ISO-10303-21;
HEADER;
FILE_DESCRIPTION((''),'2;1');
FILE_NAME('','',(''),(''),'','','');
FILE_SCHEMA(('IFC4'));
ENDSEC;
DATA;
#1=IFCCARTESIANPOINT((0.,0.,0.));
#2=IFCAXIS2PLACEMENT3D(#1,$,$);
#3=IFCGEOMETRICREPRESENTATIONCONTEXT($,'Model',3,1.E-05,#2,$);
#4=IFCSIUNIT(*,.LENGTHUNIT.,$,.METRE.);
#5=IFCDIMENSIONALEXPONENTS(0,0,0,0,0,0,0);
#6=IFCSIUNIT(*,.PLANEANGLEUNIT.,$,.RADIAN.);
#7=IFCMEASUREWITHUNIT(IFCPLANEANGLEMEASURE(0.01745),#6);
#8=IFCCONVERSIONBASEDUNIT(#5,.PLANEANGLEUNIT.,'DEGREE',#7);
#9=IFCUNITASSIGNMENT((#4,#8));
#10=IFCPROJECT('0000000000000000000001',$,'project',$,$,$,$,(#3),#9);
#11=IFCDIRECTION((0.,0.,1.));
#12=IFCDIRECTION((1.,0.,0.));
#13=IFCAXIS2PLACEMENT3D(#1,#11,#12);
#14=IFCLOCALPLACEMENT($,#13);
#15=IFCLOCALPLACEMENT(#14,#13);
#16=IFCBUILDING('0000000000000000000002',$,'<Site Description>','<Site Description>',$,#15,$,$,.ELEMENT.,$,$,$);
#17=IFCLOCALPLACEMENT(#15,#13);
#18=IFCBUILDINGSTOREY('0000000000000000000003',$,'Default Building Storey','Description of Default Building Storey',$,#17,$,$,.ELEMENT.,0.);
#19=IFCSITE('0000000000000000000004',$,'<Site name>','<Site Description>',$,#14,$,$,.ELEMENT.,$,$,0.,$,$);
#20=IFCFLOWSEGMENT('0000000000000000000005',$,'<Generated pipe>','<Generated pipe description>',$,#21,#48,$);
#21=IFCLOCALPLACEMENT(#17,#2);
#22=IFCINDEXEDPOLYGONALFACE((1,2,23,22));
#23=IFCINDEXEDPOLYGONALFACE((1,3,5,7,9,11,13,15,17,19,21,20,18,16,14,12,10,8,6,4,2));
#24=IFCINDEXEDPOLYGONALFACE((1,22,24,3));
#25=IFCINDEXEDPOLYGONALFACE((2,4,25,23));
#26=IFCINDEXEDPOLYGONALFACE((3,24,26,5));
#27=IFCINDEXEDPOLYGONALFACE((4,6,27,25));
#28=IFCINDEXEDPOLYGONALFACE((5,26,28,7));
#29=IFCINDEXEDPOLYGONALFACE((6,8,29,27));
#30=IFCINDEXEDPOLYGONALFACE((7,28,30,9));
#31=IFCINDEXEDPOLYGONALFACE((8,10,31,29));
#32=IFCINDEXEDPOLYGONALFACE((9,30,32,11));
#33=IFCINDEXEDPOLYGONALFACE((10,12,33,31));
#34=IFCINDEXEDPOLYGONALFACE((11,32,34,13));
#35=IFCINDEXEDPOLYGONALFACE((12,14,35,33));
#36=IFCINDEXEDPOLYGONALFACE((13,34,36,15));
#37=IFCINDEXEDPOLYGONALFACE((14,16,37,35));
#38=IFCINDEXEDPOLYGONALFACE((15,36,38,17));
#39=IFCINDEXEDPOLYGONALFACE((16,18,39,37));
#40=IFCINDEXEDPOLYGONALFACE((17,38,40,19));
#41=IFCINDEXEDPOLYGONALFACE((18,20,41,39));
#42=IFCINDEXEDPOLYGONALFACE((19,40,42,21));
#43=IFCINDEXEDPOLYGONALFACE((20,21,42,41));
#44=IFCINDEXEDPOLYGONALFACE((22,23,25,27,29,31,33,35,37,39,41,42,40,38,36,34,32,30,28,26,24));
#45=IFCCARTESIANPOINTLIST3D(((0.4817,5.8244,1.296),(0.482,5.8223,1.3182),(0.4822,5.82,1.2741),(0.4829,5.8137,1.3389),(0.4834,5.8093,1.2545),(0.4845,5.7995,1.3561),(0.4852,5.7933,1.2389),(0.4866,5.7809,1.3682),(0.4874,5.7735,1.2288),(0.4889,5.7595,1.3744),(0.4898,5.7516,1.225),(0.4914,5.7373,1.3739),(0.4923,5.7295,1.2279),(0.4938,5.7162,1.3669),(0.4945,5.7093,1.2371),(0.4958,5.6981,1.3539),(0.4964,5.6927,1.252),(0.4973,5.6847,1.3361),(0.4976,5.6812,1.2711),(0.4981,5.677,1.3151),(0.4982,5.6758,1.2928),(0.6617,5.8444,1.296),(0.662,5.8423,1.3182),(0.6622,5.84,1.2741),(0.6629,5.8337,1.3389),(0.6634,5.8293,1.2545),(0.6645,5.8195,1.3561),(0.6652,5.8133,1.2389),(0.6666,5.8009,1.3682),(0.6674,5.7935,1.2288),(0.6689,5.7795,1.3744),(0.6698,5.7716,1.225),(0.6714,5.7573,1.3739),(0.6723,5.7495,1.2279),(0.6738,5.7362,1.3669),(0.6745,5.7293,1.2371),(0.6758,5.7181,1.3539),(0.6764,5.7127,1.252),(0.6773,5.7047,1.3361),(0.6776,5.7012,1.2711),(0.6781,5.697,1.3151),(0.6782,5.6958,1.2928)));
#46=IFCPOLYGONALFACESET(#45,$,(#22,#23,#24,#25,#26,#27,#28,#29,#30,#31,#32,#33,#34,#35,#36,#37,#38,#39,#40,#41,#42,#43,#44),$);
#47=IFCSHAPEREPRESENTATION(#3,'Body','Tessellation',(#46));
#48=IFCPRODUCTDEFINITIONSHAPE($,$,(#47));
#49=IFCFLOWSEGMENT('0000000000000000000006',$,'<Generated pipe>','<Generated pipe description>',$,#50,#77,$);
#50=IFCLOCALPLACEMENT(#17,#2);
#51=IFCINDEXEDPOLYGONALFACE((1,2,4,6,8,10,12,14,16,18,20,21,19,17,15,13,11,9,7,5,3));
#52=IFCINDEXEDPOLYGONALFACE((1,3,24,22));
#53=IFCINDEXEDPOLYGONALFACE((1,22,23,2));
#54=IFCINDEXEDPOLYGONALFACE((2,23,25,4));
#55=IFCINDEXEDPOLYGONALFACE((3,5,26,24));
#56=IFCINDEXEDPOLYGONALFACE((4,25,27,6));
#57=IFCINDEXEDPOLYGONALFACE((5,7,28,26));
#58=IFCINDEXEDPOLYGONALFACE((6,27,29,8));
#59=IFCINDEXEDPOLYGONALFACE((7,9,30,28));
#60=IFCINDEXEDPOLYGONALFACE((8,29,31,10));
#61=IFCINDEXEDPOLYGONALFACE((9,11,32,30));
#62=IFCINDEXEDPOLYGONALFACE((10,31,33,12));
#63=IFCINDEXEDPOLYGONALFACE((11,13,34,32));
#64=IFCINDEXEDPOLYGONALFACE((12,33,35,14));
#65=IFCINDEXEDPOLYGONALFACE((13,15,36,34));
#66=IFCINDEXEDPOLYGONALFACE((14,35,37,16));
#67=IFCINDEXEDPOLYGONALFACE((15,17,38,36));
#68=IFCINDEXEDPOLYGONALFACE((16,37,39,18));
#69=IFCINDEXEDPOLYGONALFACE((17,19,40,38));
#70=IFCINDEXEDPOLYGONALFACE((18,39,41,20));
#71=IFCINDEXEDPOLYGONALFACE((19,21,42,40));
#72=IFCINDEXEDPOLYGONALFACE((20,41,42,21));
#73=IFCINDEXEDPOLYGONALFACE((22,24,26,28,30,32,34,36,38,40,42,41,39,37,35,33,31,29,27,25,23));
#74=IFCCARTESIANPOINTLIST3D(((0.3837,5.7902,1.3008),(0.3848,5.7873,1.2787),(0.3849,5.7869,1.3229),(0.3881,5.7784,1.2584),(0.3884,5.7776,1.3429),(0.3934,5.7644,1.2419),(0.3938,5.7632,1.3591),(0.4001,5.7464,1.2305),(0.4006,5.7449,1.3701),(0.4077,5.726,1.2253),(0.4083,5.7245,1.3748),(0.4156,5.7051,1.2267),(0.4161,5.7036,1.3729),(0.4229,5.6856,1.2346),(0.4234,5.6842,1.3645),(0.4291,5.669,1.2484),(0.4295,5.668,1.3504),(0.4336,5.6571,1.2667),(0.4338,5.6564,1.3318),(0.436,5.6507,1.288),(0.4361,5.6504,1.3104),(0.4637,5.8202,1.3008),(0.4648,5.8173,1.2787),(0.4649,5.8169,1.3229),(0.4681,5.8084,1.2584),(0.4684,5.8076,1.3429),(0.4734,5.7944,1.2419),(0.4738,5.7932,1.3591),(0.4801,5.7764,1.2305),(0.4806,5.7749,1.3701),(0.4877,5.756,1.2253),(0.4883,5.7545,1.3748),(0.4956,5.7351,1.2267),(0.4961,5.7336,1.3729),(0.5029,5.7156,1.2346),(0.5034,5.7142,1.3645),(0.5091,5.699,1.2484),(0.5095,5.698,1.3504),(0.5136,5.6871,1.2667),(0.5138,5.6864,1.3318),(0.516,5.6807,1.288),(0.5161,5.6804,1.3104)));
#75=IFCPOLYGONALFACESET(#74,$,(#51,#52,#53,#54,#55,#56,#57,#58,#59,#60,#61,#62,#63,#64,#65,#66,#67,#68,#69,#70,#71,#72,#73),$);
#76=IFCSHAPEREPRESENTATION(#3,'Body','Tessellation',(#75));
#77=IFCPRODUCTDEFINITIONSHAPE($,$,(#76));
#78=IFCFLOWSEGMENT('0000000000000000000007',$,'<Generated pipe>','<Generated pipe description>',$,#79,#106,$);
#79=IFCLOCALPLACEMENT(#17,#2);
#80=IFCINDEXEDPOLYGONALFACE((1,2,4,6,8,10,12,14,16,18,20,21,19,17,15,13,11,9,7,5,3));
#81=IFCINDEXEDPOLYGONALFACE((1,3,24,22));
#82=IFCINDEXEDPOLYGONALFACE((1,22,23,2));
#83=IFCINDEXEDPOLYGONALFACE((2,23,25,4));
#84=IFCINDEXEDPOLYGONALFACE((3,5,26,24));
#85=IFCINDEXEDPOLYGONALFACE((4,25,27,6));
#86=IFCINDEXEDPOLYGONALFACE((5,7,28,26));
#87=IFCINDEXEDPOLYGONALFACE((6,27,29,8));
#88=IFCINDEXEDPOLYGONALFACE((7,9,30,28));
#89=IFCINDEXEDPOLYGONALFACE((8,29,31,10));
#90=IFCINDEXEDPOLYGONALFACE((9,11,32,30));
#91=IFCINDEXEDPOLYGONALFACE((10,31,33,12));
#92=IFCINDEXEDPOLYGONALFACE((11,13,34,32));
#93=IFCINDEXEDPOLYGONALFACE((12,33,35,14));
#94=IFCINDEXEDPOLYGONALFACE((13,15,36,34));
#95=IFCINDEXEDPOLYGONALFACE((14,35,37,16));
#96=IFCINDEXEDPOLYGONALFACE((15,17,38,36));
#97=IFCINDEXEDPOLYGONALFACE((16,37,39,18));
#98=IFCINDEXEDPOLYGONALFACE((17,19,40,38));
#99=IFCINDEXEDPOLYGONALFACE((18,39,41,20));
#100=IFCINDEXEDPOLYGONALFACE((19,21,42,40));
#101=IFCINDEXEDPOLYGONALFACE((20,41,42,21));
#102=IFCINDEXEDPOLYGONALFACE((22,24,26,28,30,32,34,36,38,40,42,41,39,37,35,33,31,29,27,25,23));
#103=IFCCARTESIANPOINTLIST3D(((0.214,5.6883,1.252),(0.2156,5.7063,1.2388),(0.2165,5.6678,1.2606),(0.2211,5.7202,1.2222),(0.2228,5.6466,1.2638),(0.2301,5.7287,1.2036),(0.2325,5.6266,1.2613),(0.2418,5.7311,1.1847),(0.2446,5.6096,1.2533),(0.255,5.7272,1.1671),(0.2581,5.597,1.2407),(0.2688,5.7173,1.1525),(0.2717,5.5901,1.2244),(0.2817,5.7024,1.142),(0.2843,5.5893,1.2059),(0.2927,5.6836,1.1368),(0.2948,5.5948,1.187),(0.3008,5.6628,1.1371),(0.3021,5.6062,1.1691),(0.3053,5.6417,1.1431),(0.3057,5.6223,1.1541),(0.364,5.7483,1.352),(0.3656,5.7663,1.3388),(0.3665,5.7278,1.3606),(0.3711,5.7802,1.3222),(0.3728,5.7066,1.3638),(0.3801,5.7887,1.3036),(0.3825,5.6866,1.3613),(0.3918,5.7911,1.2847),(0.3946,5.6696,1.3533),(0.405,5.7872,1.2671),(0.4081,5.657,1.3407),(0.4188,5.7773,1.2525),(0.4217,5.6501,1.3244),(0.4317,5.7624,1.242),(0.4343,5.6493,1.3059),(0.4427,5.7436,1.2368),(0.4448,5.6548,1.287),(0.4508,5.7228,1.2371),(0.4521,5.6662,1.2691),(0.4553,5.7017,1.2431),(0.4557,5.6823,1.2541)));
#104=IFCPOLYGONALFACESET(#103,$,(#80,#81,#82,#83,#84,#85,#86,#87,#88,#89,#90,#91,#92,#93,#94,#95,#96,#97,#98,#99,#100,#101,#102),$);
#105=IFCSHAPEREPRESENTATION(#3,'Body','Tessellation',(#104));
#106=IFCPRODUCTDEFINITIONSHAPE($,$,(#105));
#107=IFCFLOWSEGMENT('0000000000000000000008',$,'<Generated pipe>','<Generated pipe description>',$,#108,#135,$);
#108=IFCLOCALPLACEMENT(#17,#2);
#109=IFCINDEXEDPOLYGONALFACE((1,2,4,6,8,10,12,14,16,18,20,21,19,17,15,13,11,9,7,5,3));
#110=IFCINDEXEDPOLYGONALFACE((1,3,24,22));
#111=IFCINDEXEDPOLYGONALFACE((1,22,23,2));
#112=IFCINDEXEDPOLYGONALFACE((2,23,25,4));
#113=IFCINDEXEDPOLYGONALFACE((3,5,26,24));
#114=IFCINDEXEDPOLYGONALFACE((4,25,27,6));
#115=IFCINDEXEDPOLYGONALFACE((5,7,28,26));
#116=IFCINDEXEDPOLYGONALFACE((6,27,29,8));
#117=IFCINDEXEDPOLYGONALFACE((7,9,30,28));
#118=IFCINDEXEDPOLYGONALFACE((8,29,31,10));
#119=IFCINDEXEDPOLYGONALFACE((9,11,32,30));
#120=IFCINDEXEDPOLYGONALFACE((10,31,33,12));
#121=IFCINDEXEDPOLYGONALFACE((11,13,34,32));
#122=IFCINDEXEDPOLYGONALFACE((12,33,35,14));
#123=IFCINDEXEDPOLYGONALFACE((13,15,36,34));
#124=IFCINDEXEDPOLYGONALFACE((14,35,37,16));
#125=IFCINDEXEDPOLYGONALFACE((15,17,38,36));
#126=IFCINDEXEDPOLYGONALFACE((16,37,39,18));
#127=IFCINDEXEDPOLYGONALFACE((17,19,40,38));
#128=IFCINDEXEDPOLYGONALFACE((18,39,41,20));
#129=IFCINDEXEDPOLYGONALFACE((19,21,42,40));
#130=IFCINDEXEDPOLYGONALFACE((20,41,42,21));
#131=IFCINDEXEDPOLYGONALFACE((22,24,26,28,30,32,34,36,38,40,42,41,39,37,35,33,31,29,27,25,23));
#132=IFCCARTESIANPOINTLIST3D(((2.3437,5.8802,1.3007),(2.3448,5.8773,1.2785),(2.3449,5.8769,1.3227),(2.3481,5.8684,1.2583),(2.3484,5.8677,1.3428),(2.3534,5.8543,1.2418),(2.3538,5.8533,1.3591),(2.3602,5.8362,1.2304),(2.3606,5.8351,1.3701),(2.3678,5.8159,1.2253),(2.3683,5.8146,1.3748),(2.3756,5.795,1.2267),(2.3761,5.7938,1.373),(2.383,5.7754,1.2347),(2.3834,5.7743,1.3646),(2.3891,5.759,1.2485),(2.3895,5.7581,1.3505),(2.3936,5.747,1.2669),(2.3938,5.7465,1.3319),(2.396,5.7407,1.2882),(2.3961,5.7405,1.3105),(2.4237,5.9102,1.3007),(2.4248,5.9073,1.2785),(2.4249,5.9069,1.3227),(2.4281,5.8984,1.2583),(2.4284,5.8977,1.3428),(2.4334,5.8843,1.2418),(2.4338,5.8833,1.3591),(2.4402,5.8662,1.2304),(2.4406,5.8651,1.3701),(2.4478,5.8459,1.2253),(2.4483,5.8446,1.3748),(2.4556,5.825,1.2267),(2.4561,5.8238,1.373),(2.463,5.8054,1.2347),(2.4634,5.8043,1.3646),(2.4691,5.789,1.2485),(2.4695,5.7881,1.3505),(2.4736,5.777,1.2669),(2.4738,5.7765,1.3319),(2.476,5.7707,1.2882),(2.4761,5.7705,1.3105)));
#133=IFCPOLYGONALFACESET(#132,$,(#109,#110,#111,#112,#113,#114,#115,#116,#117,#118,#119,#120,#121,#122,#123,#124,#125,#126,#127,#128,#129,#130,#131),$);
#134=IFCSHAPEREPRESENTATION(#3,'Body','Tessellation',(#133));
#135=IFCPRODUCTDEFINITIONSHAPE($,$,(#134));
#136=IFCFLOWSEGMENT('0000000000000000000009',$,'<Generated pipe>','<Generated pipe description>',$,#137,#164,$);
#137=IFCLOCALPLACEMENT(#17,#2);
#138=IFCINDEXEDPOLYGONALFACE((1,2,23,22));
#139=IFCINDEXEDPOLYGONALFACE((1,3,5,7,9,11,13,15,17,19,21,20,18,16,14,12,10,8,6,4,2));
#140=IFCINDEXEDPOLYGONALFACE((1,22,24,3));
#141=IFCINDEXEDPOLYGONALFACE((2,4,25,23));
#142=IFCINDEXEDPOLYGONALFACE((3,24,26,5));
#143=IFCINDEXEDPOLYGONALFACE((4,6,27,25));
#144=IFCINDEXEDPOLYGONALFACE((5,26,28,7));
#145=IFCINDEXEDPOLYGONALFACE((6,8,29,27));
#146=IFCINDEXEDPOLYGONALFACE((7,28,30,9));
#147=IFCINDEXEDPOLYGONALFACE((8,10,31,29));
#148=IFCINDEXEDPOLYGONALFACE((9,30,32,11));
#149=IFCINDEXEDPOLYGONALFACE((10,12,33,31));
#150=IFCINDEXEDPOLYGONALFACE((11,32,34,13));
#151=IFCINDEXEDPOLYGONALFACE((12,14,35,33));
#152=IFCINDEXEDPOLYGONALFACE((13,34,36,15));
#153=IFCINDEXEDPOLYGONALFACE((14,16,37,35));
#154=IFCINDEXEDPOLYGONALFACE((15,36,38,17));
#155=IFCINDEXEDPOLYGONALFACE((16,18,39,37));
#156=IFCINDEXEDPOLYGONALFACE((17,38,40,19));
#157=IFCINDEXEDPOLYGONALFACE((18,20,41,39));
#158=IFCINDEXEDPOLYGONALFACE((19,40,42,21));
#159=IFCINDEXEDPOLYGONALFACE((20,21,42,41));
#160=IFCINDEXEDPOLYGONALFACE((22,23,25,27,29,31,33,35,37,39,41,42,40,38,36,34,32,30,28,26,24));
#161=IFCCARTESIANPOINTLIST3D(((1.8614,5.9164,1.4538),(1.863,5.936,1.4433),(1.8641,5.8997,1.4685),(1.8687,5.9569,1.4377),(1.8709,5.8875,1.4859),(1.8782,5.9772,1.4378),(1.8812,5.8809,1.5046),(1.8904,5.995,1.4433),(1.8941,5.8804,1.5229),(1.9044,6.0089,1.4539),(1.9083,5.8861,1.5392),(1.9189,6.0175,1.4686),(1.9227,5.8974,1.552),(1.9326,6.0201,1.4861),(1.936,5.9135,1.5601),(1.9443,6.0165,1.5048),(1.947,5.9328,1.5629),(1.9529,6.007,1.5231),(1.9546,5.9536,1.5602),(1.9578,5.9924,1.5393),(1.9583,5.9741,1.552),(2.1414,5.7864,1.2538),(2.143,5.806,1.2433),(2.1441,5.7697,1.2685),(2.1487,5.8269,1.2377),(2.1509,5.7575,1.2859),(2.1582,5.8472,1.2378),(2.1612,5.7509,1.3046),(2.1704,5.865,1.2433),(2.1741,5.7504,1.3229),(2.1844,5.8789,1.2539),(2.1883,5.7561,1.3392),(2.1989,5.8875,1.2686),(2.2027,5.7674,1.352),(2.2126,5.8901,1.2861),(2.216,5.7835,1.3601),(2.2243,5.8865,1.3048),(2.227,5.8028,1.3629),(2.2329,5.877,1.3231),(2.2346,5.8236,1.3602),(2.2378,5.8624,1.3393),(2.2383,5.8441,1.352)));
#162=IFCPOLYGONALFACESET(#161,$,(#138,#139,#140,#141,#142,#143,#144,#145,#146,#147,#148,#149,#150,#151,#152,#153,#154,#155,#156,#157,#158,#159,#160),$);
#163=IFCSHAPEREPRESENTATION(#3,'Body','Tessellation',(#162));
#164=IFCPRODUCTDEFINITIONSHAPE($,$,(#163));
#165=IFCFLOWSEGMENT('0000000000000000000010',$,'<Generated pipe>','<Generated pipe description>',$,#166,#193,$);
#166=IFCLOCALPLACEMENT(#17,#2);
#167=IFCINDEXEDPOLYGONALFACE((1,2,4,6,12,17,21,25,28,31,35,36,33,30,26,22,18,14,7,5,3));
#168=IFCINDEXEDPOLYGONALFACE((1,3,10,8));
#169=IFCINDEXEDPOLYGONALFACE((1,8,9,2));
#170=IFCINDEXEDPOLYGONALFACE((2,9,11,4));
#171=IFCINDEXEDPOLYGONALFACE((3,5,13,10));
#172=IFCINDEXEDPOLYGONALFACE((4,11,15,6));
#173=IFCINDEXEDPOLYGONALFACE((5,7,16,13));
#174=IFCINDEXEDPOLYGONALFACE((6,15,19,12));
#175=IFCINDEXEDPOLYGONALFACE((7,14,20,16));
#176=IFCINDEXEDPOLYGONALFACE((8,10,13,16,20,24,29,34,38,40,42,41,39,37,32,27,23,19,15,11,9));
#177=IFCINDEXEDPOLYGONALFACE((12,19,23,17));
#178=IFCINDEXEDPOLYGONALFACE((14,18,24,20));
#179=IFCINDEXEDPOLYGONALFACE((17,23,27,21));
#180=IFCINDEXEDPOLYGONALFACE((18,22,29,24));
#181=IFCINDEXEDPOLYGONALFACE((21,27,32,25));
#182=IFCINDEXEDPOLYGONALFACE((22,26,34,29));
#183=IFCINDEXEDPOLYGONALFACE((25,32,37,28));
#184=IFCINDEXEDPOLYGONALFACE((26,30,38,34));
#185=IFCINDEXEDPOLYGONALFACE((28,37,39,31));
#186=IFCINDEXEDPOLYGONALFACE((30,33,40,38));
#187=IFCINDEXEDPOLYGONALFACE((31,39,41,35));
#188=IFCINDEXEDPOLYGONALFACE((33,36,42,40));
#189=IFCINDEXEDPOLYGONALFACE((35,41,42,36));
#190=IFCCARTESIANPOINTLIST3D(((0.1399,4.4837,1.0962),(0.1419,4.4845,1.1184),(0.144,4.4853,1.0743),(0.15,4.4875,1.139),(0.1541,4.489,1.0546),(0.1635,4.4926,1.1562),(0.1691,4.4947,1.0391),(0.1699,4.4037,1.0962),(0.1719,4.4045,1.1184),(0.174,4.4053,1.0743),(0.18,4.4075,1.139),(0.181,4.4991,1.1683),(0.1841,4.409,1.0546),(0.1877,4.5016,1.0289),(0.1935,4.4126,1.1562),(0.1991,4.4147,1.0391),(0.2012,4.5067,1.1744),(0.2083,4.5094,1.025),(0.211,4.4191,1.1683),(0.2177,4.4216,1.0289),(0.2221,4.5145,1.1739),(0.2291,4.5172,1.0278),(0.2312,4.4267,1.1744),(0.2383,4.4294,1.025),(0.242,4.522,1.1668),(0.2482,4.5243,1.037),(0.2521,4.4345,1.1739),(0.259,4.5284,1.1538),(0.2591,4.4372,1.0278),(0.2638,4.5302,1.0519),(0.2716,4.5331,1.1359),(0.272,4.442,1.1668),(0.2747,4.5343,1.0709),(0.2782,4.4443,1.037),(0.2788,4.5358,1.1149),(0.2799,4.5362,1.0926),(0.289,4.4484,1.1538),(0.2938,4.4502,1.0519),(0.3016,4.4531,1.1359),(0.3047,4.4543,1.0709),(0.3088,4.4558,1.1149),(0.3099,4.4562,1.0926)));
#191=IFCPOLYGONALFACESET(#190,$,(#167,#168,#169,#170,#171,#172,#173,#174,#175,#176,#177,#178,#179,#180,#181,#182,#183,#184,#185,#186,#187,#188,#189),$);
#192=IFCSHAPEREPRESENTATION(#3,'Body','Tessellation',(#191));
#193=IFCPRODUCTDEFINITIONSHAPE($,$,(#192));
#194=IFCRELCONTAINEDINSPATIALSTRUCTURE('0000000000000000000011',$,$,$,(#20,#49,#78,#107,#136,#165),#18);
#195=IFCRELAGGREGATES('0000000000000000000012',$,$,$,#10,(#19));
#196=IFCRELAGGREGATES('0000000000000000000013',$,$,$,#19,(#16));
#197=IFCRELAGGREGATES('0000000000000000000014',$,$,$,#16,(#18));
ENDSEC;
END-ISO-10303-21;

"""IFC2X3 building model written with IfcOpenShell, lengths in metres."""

from ifc_helpers import new_model, entity, si_unit, converted_unit, frame, origin, origin_with_axes, origin_2d_with_axis, place, context, project, spatial, circle, extrude, element, save


model = new_model("IFC2X3")

# Units and contexts
model_context = context("Model", 3, precision=1e-05, world=origin())
ifc_project = project(units=[si_unit("LENGTHUNIT", "METRE"), converted_unit("PLANEANGLEUNIT", "DEGREE", entity("IfcPlaneAngleMeasure", 0.01745), si_unit("PLANEANGLEUNIT", "RADIAN"), dimensions=[0, 0, 0, 0, 0, 0, 0])], contexts=[model_context])

# Site, building, storey
site_placement = place(None, origin_with_axes())
site = spatial("IfcSite", under=ifc_project, at=site_placement, Name="<Site name>", Description="<Site Description>", CompositionType="ELEMENT", RefElevation=0.0)
building_placement = place(site_placement, origin_with_axes())
building = spatial("IfcBuilding", under=site, at=building_placement, Name="<Site Description>", Description="<Site Description>", CompositionType="ELEMENT")
storey_placement = place(building_placement, origin_with_axes())
storey = spatial("IfcBuildingStorey", under=building, at=storey_placement, Name="Default Building Storey", Description="Description of Default Building Storey", CompositionType="ELEMENT", Elevation=0.0)

# Flow segments
flow_segment_1_placement = place(storey_placement, frame((0.67, 5.77, 1.3), z_axis=(-0.993884, -0.110432, 0.0), x_axis=(-0.073375, 0.660372, 0.747345)))
element("IfcFlowSegment", 1, at=flow_segment_1_placement, inside=storey, Name="<Generated pipe>", Description="<Generated pipe description>", context=model_context, shape_type="SweptSolid", body=[
    extrude(circle(Radius=0.075, at=origin_2d_with_axis()), origin_with_axes(), (0.0, 0.0, 1.0), 0.1811),
])
flow_segment_2_placement = place(storey_placement, frame((0.49, 5.75, 1.3), z_axis=(-0.936329, -0.351123, 0.0), x_axis=(-0.351103, 0.936274, 0.010885)))
element("IfcFlowSegment", 2, at=flow_segment_2_placement, inside=storey, Name="<Generated pipe>", Description="<Generated pipe description>", context=model_context, shape_type="SweptSolid", body=[
    extrude(circle(Radius=0.075, at=origin_2d_with_axis()), origin_with_axes(), (0.0, 0.0, 1.0), 0.0854),
])
flow_segment_3_placement = place(storey_placement, frame((0.41, 5.72, 1.3), z_axis=(-0.789474, -0.315789, -0.526316), x_axis=(-0.205221, -0.672334, 0.711232)))
element("IfcFlowSegment", 3, at=flow_segment_3_placement, inside=storey, Name="<Generated pipe>", Description="<Generated pipe description>", context=model_context, shape_type="SweptSolid", body=[
    extrude(circle(Radius=0.075, at=origin_2d_with_axis()), origin_with_axes(), (0.0, 0.0, 1.0), 0.19),
])
flow_segment_4_placement = place(storey_placement, frame((2.45, 5.84, 1.3), z_axis=(-0.936329, -0.351123, 0.0), x_axis=(-0.334582, 0.892218, 0.303317)))
element("IfcFlowSegment", 4, at=flow_segment_4_placement, inside=storey, Name="<Generated pipe>", Description="<Generated pipe description>", context=model_context, shape_type="SweptSolid", body=[
    extrude(circle(Radius=0.075, at=origin_2d_with_axis()), origin_with_axes(), (0.0, 0.0, 1.0), 0.0854),
])
flow_segment_5_placement = place(storey_placement, frame((2.19, 5.82, 1.3), z_axis=(-0.761218, 0.353423, 0.543727), x_axis=(0.636854, 0.565566, 0.523977)))
element("IfcFlowSegment", 5, at=flow_segment_5_placement, inside=storey, Name="<Generated pipe>", Description="<Generated pipe description>", context=model_context, shape_type="SweptSolid", body=[
    extrude(circle(Radius=0.075, at=origin_2d_with_axis()), origin_with_axes(), (0.0, 0.0, 1.0), 0.3678),
])
flow_segment_6_placement = place(storey_placement, frame((0.24, 4.43, 1.1), z_axis=(-0.351123, 0.936329, 0.0), x_axis=(0.821787, 0.30817, 0.479268)))
element("IfcFlowSegment", 6, at=flow_segment_6_placement, inside=storey, Name="<Generated pipe>", Description="<Generated pipe description>", context=model_context, shape_type="SweptSolid", body=[
    extrude(circle(Radius=0.075, at=origin_2d_with_axis()), origin_with_axes(), (0.0, 0.0, 1.0), 0.0854),
])

save(model, "model.ifc")
